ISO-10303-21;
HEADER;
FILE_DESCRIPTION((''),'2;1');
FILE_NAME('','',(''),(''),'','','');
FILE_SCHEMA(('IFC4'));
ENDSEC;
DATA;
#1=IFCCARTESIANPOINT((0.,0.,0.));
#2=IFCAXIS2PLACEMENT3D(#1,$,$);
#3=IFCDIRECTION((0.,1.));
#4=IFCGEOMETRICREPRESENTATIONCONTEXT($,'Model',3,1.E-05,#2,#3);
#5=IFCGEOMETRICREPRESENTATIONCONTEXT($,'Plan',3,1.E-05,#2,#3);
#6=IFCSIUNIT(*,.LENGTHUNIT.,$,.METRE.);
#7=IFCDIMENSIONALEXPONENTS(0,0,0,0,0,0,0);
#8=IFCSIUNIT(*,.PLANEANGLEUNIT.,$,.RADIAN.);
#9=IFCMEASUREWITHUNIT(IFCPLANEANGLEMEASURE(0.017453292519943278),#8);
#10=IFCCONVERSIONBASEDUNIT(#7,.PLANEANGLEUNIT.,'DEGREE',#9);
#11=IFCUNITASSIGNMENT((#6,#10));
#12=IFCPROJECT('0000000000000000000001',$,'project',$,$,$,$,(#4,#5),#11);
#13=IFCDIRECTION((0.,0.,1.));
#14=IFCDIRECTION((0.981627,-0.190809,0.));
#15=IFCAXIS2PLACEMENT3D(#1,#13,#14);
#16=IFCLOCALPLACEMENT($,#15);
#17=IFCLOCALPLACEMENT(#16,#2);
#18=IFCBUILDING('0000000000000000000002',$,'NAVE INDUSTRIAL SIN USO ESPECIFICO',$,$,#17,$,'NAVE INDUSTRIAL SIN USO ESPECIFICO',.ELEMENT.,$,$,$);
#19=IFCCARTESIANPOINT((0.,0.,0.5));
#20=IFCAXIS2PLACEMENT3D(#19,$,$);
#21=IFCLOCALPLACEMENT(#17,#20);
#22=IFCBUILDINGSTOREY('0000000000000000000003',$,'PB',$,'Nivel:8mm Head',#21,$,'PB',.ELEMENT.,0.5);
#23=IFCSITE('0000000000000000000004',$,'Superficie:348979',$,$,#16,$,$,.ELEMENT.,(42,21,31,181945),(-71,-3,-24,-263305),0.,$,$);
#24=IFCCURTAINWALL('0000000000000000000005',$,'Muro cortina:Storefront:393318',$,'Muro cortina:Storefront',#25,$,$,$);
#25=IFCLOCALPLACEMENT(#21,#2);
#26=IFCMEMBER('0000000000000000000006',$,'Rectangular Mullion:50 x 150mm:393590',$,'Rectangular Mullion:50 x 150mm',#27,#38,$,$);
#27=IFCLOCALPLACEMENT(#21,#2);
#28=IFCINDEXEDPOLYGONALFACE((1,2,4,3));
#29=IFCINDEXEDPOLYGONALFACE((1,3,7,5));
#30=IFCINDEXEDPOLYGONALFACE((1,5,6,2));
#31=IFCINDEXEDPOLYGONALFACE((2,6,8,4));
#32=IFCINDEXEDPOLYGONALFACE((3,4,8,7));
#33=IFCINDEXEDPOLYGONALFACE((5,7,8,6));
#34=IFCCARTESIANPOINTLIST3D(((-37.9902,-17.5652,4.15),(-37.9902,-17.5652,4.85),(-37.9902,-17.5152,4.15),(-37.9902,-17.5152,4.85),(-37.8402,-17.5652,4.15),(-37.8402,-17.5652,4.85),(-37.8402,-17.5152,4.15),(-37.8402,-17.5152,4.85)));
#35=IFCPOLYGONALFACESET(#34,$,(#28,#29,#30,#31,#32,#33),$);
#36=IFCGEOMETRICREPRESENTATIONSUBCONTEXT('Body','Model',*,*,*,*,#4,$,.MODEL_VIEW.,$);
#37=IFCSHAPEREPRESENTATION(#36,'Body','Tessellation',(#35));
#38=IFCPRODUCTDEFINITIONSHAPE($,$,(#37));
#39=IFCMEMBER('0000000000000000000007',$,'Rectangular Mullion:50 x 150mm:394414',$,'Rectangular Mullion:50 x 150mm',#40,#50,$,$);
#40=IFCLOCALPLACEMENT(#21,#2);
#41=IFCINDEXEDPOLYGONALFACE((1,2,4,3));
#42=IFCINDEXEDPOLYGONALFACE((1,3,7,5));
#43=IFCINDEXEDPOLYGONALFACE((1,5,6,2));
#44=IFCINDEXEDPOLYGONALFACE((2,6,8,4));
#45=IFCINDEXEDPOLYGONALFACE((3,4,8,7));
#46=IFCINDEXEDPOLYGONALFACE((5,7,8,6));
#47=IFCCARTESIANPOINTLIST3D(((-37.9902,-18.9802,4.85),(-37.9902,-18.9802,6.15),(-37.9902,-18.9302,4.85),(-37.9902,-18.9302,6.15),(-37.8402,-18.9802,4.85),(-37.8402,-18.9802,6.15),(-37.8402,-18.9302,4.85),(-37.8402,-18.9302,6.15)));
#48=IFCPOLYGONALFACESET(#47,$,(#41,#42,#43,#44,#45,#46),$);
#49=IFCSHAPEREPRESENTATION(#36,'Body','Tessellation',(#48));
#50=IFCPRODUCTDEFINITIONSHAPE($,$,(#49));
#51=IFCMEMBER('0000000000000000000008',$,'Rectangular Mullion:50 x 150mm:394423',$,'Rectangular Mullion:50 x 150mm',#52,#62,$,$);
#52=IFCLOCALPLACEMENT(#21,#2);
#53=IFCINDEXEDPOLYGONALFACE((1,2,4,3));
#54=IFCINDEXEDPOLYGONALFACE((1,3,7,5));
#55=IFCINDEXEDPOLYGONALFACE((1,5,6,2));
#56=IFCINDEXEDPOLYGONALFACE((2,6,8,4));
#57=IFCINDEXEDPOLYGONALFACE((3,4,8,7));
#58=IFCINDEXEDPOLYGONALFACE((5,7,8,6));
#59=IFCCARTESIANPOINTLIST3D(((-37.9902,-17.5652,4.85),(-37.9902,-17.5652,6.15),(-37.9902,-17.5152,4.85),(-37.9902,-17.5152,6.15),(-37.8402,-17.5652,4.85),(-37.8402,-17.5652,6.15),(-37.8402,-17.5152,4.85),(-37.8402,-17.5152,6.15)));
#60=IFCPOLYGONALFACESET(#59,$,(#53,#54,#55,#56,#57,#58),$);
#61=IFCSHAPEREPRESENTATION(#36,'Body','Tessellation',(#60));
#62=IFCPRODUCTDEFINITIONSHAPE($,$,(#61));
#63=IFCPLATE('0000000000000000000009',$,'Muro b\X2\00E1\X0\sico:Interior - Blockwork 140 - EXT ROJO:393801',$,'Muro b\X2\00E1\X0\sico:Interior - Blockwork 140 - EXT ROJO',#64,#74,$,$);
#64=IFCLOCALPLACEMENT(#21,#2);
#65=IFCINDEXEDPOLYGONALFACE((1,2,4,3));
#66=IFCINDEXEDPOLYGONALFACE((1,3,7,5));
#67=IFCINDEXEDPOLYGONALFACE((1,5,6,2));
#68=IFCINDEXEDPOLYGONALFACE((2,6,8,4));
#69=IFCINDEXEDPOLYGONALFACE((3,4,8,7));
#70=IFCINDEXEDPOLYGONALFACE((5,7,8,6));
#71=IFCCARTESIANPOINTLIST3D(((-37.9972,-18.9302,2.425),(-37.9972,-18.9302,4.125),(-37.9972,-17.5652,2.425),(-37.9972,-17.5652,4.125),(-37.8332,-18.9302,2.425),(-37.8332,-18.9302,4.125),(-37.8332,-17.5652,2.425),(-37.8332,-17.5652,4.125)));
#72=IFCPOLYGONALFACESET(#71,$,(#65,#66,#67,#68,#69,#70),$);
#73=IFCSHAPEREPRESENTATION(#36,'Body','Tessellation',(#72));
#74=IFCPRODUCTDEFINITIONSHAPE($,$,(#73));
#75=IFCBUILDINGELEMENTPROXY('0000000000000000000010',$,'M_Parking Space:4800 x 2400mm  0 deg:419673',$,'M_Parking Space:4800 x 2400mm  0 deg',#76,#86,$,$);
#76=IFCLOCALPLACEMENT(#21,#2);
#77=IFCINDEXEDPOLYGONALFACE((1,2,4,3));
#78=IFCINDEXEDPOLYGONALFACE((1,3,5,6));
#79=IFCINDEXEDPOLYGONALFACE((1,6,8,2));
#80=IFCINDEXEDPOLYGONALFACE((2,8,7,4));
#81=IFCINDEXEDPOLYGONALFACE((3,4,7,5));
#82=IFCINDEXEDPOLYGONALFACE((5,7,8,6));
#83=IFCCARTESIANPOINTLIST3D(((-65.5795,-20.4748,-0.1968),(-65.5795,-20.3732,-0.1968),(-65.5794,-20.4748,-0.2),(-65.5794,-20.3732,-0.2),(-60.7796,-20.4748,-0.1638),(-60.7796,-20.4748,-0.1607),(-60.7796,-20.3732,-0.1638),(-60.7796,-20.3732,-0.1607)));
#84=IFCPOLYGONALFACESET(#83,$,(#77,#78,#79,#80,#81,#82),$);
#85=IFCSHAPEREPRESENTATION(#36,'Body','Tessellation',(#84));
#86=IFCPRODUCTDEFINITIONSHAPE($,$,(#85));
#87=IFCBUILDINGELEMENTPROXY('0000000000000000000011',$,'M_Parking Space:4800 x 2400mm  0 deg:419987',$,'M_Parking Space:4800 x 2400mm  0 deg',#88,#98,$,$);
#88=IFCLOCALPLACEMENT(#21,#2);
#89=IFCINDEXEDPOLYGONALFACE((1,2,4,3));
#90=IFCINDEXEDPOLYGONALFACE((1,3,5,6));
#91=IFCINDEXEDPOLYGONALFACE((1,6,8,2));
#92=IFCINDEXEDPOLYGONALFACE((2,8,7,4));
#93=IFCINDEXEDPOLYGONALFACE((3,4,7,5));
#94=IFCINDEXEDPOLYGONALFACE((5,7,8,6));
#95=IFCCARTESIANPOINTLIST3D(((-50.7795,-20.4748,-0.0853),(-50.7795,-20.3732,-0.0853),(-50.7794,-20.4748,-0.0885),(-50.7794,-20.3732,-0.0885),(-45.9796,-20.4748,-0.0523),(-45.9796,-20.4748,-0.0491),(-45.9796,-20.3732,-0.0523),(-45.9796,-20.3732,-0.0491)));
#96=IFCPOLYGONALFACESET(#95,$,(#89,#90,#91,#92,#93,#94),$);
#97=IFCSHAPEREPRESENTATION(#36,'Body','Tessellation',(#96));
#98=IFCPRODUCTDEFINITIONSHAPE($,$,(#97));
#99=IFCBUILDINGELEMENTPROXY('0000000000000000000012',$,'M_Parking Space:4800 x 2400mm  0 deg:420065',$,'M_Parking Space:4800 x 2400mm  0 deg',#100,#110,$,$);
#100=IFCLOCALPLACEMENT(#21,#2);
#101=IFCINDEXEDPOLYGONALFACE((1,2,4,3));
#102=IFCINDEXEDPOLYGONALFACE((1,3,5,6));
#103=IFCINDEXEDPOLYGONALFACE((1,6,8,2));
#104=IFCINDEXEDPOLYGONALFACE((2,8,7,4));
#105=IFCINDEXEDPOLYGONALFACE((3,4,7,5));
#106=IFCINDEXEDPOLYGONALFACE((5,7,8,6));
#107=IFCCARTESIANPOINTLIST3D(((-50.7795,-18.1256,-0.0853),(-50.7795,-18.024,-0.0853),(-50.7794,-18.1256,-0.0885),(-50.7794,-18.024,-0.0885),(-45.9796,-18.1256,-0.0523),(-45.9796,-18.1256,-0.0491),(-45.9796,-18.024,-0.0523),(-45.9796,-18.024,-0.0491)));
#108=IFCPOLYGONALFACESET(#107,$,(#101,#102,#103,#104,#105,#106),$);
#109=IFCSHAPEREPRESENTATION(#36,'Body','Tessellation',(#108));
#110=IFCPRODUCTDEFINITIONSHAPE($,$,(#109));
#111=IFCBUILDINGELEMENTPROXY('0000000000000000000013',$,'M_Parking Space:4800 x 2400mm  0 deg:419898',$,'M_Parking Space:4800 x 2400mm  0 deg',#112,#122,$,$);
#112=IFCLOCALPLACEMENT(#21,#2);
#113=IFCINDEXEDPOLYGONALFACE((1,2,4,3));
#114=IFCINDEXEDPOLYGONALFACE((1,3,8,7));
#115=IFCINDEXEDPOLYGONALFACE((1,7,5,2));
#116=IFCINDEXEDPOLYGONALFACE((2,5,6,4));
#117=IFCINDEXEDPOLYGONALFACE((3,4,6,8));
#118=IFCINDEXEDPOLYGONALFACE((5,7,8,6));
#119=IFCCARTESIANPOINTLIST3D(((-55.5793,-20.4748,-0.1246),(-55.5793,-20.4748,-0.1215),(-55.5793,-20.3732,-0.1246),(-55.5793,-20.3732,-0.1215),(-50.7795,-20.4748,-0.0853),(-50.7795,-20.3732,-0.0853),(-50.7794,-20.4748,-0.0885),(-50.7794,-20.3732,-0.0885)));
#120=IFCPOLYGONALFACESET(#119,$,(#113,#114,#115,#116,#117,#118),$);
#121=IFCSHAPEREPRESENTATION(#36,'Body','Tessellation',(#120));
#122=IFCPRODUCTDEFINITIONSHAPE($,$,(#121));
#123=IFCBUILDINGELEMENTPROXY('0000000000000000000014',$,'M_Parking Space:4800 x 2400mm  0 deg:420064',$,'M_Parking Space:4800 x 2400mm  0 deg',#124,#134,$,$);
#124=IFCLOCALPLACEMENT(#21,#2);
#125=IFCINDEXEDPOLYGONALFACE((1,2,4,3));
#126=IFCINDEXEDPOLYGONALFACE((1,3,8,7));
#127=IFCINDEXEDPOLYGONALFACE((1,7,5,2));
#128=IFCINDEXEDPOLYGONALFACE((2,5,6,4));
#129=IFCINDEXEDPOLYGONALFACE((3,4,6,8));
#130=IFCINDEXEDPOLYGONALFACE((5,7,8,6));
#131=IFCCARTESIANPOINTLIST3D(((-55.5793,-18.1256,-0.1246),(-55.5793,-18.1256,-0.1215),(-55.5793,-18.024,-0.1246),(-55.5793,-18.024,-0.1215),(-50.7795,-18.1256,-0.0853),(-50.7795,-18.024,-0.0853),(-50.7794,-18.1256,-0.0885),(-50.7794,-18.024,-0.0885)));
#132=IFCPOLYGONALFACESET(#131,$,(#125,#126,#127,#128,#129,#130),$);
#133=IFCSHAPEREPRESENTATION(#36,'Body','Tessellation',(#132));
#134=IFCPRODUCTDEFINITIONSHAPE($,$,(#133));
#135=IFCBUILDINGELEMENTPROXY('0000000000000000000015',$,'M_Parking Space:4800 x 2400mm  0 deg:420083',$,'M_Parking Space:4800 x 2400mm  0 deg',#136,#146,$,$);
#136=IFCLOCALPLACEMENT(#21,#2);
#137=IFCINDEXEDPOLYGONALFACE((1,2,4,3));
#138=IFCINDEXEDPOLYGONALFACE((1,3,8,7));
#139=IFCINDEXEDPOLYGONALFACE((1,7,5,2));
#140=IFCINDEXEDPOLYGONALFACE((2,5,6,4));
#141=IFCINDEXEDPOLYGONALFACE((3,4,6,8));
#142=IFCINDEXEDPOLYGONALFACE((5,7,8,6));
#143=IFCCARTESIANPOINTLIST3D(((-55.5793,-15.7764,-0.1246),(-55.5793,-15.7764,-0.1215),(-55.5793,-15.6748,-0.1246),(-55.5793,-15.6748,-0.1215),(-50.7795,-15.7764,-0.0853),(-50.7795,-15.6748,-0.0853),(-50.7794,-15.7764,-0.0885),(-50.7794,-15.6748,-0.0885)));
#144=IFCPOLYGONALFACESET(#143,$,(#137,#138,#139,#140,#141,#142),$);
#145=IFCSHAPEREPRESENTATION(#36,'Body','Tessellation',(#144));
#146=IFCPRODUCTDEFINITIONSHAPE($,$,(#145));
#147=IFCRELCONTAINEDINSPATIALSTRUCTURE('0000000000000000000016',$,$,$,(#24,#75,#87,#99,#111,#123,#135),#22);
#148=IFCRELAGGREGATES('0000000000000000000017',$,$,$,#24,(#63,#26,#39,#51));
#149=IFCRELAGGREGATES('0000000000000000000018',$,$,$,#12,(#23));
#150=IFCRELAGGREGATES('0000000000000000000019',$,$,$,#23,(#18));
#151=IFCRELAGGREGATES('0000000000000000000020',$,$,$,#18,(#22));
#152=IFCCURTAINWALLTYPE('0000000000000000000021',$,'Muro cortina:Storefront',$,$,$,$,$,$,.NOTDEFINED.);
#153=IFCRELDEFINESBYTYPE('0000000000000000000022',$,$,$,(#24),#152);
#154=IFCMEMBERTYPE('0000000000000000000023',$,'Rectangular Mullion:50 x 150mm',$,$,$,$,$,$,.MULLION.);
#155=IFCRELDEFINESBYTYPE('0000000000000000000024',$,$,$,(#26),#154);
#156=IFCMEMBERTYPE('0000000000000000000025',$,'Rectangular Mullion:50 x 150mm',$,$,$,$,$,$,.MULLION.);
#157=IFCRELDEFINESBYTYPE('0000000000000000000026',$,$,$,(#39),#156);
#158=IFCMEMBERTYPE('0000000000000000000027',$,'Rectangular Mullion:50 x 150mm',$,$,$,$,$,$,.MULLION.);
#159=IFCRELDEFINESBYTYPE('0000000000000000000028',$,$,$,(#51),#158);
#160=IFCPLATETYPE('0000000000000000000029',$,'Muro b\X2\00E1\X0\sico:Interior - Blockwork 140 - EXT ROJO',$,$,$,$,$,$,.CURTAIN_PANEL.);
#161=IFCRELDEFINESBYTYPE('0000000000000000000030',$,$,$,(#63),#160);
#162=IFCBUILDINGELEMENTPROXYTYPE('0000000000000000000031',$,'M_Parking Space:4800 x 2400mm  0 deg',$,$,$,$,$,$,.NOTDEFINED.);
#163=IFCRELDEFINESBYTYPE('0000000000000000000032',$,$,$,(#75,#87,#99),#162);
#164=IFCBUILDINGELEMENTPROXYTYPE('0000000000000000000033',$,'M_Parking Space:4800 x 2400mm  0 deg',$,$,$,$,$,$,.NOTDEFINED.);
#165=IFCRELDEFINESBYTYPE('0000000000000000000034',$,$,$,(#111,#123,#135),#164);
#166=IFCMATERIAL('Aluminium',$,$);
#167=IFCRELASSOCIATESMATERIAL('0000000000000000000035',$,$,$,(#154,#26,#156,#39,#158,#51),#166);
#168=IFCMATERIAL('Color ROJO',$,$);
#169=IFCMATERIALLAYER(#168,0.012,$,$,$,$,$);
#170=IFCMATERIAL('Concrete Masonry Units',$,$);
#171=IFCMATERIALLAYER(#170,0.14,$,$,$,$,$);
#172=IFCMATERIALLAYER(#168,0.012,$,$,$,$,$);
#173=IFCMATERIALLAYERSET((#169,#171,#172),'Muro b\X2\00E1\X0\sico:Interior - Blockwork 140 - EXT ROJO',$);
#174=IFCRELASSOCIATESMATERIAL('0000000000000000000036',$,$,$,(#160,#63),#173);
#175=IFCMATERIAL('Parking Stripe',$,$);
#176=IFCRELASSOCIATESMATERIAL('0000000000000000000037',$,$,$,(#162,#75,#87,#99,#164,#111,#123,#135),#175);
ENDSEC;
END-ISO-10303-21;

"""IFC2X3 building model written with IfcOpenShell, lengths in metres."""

from ifc_helpers import new_model, entity, si_unit, converted_unit, direction, frame, frame_2d, origin, origin_2d_with_axis, place, context, subcontext, project, spatial, rectangle, extrude, source, transform, mapped, material, layer, layer_set, layer_usage, type_object, type_shapes, element, aggregate, save


model = new_model("IFC2X3")

# Units and contexts
model_context = context("Model", 3, precision=1e-05, world=origin(), true_north=direction((0.0, 1.0)))
plan_context = context("Plan", 3, precision=1e-05, world=origin(), true_north=direction((0.0, 1.0)))
body_context = subcontext(model_context, "Body", "Model", "MODEL_VIEW")
ifc_project = project(units=[si_unit("LENGTHUNIT", "METRE"), converted_unit("PLANEANGLEUNIT", "DEGREE", entity("IfcPlaneAngleMeasure", 0.017453292519943278), si_unit("PLANEANGLEUNIT", "RADIAN"), dimensions=[0, 0, 0, 0, 0, 0, 0])], contexts=[model_context, plan_context])

# Site, building, storey
site_placement = place(None, frame((0.0, 0.0, 0.0), z_axis=(0.0, 0.0, 1.0), x_axis=(0.981627, -0.190809, 0.0)))
site = spatial("IfcSite", under=ifc_project, at=site_placement, Name="Superficie:348979", CompositionType="ELEMENT", RefLatitude=(42, 21, 31, 181945), RefLongitude=(-71, -3, -24, -263305), RefElevation=0.0)
building_placement = place(site_placement, origin())
building = spatial("IfcBuilding", under=site, at=building_placement, Name="NAVE INDUSTRIAL SIN USO ESPECIFICO", LongName="NAVE INDUSTRIAL SIN USO ESPECIFICO", CompositionType="ELEMENT")
storey_placement = place(building_placement, frame((0.0, 0.0, 0.5)))
storey = spatial("IfcBuildingStorey", under=building, at=storey_placement, Name="PB", ObjectType="Nivel:8mm Head", LongName="PB", CompositionType="ELEMENT", Elevation=0.5)

# Curtain wall, members, plate
curtain_wall_type = type_object("IfcCurtainWallType", Name="Muro cortina:Storefront", PredefinedType="NOTDEFINED")
curtain_wall_placement = place(storey_placement, frame((0.0, 0.0, -0.5)))
curtain_wall = element("IfcCurtainWall", 1, at=curtain_wall_placement, inside=storey, type_object=curtain_wall_type, Name="Muro cortina:Storefront:393318", ObjectType="Muro cortina:Storefront")
ifc_material_1 = material(Name="Aluminium")
member_type_1 = type_object("IfcMemberType", Name="Rectangular Mullion:50 x 150mm", PredefinedType="MULLION", material=ifc_material_1)
shared_shape_1 = source(origin(), body_context, "Body", "SweptSolid", [
    extrude(rectangle(XDim=0.05, YDim=0.15, at=origin_2d_with_axis()), frame((0.0, 0.0, -0.7), z_axis=(0.0, 0.0, 1.0), x_axis=(-1.0, 0.0, 0.0)), (0.0, 0.0, 1.0), 0.7),
])
type_shapes(member_type_1, [shared_shape_1])
member_1_placement = place(curtain_wall_placement, frame((-37.9152, -17.5402, 4.65), z_axis=(0.0, 0.0, -1.0), x_axis=(0.0, -1.0, 0.0)))
member_1 = element("IfcMember", 2, at=member_1_placement, type_object=member_type_1, material=ifc_material_1, Name="Rectangular Mullion:50 x 150mm:393590", ObjectType="Rectangular Mullion:50 x 150mm", context=body_context, shape_type="MappedRepresentation", body=[
    mapped(shared_shape_1, transform((0.0, 0.0, 0.0), scale=1.0)),
])
member_type_2 = type_object("IfcMemberType", Name="Rectangular Mullion:50 x 150mm", PredefinedType="MULLION", material=ifc_material_1)
shared_shape_2 = source(origin(), body_context, "Body", "SweptSolid", [
    extrude(rectangle(XDim=0.05, YDim=0.15, at=origin_2d_with_axis()), frame((-0.025, 0.0, -1.3), z_axis=(0.0, 0.0, 1.0), x_axis=(-1.0, 0.0, 0.0)), (0.0, 0.0, 1.0), 1.3),
])
type_shapes(member_type_2, [shared_shape_2])
member_2_placement = place(curtain_wall_placement, frame((-37.9152, -18.9802, 5.35), z_axis=(0.0, 0.0, -1.0), x_axis=(0.0, -1.0, 0.0)))
member_2 = element("IfcMember", 3, at=member_2_placement, type_object=member_type_2, material=ifc_material_1, Name="Rectangular Mullion:50 x 150mm:394414", ObjectType="Rectangular Mullion:50 x 150mm", context=body_context, shape_type="MappedRepresentation", body=[
    mapped(shared_shape_2, transform((0.0, 0.0, 0.0), scale=1.0)),
])
member_type_3 = type_object("IfcMemberType", Name="Rectangular Mullion:50 x 150mm", PredefinedType="MULLION", material=ifc_material_1)
shared_shape_3 = source(origin(), body_context, "Body", "SweptSolid", [
    extrude(rectangle(XDim=0.05, YDim=0.15, at=origin_2d_with_axis()), frame((0.0, 0.0, -1.3), z_axis=(0.0, 0.0, 1.0), x_axis=(-1.0, 0.0, 0.0)), (0.0, 0.0, 1.0), 1.3),
])
type_shapes(member_type_3, [shared_shape_3])
member_3_placement = place(curtain_wall_placement, frame((-37.9152, -17.5402, 5.35), z_axis=(0.0, 0.0, -1.0), x_axis=(0.0, -1.0, 0.0)))
member_3 = element("IfcMember", 4, at=member_3_placement, type_object=member_type_3, material=ifc_material_1, Name="Rectangular Mullion:50 x 150mm:394423", ObjectType="Rectangular Mullion:50 x 150mm", context=body_context, shape_type="MappedRepresentation", body=[
    mapped(shared_shape_3, transform((0.0, 0.0, 0.0), scale=1.0)),
])
ifc_material_2 = material(Name="Color ROJO")
ifc_layer_1 = layer(ifc_material_2, 0.012)
ifc_material_3 = material(Name="Concrete Masonry Units")
ifc_layer_2 = layer(ifc_material_3, 0.14)
ifc_layer_3 = layer(ifc_material_2, 0.012)
ifc_layer_set = layer_set([ifc_layer_1, ifc_layer_2, ifc_layer_3], Name="Muro básico:Interior - Blockwork 140 - EXT ROJO")
ifc_layer_usage = layer_usage(ifc_layer_set, "AXIS2", "NEGATIVE", 0.082)
plate_type = type_object("IfcPlateType", Name="Muro básico:Interior - Blockwork 140 - EXT ROJO", PredefinedType="CURTAIN_PANEL", material=ifc_layer_set)
plate_placement = place(storey_placement, frame((-37.9152, -17.5652, 2.425), z_axis=(0.0, 0.0, 1.0), x_axis=(0.0, -1.0, 0.0)))
plate = element("IfcPlate", 5, at=plate_placement, type_object=plate_type, material=ifc_layer_usage, Name="Muro básico:Interior - Blockwork 140 - EXT ROJO:393801", ObjectType="Muro básico:Interior - Blockwork 140 - EXT ROJO", context=body_context, shape_type="SweptSolid", body=[
    extrude(rectangle(XDim=0.164, YDim=1.365, at=frame_2d((0.0, 0.0), x_axis=(1.0, 0.0))), frame((0.6825, 0.0, 0.0), z_axis=(0.0, 0.0, 1.0), x_axis=(0.0, 1.0, 0.0)), (0.0, 0.0, 1.0), 1.7),
])
aggregate(curtain_wall, [plate, member_1, member_2, member_3])

# Building element proxies
ifc_material_4 = material(Name="Parking Stripe")
building_element_proxy_type_1 = type_object("IfcBuildingElementProxyType", Name="M_Parking Space:4800 x 2400mm  0 deg", PredefinedType="NOTDEFINED", material=ifc_material_4)
shared_shape_4 = source(origin(), body_context, "Body", "SweptSolid", [
    extrude(rectangle(XDim=4.8, YDim=0.1016, at=origin_2d_with_axis()), frame((0.0, -2.4, 0.0), z_axis=(0.0, 0.0, 1.0), x_axis=(0.0, -1.0, 0.0)), (0.0, 0.0, 1.0), 0.0032),
])
type_shapes(building_element_proxy_type_1, [shared_shape_4])
for number, where, z_axis, x_axis, name in (
    (6, (-65.5794, -20.424, -0.2), (-0.007536, 0.0, 0.999972), (0.0, 1.0, 0.0), "M_Parking Space:4800 x 2400mm  0 deg:419673"),
    (7, (-50.7794, -20.424, -0.0885), (-0.007536, 0.0, 0.999972), (0.0, 1.0, 0.0), "M_Parking Space:4800 x 2400mm  0 deg:419987"),
    (8, (-50.7794, -18.0748, -0.0885), (-0.007536, 0.0, 0.999972), (0.0, 1.0, 0.0), "M_Parking Space:4800 x 2400mm  0 deg:420065"),
):
    element("IfcBuildingElementProxy", number, at=place(storey_placement, frame(where, z_axis=z_axis, x_axis=x_axis)), inside=storey, type_object=building_element_proxy_type_1, material=ifc_material_4, Name=name, ObjectType="M_Parking Space:4800 x 2400mm  0 deg", context=body_context, shape_type="MappedRepresentation", body=[
        mapped(shared_shape_4, transform((0.0, 0.0, 0.0), scale=1.0)),
    ])
building_element_proxy_type_2 = type_object("IfcBuildingElementProxyType", Name="M_Parking Space:4800 x 2400mm  0 deg", PredefinedType="NOTDEFINED", material=ifc_material_4)
shared_shape_5 = source(origin(), body_context, "Body", "SweptSolid", [
    extrude(rectangle(XDim=0.1016, YDim=4.8, at=origin_2d_with_axis()), frame((0.0, 2.4, 0.0)), (0.0, 0.0, 1.0), 0.0032),
])
type_shapes(building_element_proxy_type_2, [shared_shape_5])
for number, where, z_axis, x_axis, name in (
    (9, (-50.7794, -20.424, -0.0885), (-0.007536, 0.0, 0.999972), (0.0, 1.0, 0.0), "M_Parking Space:4800 x 2400mm  0 deg:419898"),
    (10, (-50.7794, -18.0748, -0.0885), (-0.007536, 0.0, 0.999972), (0.0, 1.0, 0.0), "M_Parking Space:4800 x 2400mm  0 deg:420064"),
    (11, (-50.7794, -15.7256, -0.0885), (-0.007536, 0.0, 0.999972), (0.0, 1.0, 0.0), "M_Parking Space:4800 x 2400mm  0 deg:420083"),
):
    element("IfcBuildingElementProxy", number, at=place(storey_placement, frame(where, z_axis=z_axis, x_axis=x_axis)), inside=storey, type_object=building_element_proxy_type_2, material=ifc_material_4, Name=name, ObjectType="M_Parking Space:4800 x 2400mm  0 deg", context=body_context, shape_type="MappedRepresentation", body=[
        mapped(shared_shape_5, transform((0.0, 0.0, 0.0), scale=1.0)),
    ])

save(model, "model.ifc")
